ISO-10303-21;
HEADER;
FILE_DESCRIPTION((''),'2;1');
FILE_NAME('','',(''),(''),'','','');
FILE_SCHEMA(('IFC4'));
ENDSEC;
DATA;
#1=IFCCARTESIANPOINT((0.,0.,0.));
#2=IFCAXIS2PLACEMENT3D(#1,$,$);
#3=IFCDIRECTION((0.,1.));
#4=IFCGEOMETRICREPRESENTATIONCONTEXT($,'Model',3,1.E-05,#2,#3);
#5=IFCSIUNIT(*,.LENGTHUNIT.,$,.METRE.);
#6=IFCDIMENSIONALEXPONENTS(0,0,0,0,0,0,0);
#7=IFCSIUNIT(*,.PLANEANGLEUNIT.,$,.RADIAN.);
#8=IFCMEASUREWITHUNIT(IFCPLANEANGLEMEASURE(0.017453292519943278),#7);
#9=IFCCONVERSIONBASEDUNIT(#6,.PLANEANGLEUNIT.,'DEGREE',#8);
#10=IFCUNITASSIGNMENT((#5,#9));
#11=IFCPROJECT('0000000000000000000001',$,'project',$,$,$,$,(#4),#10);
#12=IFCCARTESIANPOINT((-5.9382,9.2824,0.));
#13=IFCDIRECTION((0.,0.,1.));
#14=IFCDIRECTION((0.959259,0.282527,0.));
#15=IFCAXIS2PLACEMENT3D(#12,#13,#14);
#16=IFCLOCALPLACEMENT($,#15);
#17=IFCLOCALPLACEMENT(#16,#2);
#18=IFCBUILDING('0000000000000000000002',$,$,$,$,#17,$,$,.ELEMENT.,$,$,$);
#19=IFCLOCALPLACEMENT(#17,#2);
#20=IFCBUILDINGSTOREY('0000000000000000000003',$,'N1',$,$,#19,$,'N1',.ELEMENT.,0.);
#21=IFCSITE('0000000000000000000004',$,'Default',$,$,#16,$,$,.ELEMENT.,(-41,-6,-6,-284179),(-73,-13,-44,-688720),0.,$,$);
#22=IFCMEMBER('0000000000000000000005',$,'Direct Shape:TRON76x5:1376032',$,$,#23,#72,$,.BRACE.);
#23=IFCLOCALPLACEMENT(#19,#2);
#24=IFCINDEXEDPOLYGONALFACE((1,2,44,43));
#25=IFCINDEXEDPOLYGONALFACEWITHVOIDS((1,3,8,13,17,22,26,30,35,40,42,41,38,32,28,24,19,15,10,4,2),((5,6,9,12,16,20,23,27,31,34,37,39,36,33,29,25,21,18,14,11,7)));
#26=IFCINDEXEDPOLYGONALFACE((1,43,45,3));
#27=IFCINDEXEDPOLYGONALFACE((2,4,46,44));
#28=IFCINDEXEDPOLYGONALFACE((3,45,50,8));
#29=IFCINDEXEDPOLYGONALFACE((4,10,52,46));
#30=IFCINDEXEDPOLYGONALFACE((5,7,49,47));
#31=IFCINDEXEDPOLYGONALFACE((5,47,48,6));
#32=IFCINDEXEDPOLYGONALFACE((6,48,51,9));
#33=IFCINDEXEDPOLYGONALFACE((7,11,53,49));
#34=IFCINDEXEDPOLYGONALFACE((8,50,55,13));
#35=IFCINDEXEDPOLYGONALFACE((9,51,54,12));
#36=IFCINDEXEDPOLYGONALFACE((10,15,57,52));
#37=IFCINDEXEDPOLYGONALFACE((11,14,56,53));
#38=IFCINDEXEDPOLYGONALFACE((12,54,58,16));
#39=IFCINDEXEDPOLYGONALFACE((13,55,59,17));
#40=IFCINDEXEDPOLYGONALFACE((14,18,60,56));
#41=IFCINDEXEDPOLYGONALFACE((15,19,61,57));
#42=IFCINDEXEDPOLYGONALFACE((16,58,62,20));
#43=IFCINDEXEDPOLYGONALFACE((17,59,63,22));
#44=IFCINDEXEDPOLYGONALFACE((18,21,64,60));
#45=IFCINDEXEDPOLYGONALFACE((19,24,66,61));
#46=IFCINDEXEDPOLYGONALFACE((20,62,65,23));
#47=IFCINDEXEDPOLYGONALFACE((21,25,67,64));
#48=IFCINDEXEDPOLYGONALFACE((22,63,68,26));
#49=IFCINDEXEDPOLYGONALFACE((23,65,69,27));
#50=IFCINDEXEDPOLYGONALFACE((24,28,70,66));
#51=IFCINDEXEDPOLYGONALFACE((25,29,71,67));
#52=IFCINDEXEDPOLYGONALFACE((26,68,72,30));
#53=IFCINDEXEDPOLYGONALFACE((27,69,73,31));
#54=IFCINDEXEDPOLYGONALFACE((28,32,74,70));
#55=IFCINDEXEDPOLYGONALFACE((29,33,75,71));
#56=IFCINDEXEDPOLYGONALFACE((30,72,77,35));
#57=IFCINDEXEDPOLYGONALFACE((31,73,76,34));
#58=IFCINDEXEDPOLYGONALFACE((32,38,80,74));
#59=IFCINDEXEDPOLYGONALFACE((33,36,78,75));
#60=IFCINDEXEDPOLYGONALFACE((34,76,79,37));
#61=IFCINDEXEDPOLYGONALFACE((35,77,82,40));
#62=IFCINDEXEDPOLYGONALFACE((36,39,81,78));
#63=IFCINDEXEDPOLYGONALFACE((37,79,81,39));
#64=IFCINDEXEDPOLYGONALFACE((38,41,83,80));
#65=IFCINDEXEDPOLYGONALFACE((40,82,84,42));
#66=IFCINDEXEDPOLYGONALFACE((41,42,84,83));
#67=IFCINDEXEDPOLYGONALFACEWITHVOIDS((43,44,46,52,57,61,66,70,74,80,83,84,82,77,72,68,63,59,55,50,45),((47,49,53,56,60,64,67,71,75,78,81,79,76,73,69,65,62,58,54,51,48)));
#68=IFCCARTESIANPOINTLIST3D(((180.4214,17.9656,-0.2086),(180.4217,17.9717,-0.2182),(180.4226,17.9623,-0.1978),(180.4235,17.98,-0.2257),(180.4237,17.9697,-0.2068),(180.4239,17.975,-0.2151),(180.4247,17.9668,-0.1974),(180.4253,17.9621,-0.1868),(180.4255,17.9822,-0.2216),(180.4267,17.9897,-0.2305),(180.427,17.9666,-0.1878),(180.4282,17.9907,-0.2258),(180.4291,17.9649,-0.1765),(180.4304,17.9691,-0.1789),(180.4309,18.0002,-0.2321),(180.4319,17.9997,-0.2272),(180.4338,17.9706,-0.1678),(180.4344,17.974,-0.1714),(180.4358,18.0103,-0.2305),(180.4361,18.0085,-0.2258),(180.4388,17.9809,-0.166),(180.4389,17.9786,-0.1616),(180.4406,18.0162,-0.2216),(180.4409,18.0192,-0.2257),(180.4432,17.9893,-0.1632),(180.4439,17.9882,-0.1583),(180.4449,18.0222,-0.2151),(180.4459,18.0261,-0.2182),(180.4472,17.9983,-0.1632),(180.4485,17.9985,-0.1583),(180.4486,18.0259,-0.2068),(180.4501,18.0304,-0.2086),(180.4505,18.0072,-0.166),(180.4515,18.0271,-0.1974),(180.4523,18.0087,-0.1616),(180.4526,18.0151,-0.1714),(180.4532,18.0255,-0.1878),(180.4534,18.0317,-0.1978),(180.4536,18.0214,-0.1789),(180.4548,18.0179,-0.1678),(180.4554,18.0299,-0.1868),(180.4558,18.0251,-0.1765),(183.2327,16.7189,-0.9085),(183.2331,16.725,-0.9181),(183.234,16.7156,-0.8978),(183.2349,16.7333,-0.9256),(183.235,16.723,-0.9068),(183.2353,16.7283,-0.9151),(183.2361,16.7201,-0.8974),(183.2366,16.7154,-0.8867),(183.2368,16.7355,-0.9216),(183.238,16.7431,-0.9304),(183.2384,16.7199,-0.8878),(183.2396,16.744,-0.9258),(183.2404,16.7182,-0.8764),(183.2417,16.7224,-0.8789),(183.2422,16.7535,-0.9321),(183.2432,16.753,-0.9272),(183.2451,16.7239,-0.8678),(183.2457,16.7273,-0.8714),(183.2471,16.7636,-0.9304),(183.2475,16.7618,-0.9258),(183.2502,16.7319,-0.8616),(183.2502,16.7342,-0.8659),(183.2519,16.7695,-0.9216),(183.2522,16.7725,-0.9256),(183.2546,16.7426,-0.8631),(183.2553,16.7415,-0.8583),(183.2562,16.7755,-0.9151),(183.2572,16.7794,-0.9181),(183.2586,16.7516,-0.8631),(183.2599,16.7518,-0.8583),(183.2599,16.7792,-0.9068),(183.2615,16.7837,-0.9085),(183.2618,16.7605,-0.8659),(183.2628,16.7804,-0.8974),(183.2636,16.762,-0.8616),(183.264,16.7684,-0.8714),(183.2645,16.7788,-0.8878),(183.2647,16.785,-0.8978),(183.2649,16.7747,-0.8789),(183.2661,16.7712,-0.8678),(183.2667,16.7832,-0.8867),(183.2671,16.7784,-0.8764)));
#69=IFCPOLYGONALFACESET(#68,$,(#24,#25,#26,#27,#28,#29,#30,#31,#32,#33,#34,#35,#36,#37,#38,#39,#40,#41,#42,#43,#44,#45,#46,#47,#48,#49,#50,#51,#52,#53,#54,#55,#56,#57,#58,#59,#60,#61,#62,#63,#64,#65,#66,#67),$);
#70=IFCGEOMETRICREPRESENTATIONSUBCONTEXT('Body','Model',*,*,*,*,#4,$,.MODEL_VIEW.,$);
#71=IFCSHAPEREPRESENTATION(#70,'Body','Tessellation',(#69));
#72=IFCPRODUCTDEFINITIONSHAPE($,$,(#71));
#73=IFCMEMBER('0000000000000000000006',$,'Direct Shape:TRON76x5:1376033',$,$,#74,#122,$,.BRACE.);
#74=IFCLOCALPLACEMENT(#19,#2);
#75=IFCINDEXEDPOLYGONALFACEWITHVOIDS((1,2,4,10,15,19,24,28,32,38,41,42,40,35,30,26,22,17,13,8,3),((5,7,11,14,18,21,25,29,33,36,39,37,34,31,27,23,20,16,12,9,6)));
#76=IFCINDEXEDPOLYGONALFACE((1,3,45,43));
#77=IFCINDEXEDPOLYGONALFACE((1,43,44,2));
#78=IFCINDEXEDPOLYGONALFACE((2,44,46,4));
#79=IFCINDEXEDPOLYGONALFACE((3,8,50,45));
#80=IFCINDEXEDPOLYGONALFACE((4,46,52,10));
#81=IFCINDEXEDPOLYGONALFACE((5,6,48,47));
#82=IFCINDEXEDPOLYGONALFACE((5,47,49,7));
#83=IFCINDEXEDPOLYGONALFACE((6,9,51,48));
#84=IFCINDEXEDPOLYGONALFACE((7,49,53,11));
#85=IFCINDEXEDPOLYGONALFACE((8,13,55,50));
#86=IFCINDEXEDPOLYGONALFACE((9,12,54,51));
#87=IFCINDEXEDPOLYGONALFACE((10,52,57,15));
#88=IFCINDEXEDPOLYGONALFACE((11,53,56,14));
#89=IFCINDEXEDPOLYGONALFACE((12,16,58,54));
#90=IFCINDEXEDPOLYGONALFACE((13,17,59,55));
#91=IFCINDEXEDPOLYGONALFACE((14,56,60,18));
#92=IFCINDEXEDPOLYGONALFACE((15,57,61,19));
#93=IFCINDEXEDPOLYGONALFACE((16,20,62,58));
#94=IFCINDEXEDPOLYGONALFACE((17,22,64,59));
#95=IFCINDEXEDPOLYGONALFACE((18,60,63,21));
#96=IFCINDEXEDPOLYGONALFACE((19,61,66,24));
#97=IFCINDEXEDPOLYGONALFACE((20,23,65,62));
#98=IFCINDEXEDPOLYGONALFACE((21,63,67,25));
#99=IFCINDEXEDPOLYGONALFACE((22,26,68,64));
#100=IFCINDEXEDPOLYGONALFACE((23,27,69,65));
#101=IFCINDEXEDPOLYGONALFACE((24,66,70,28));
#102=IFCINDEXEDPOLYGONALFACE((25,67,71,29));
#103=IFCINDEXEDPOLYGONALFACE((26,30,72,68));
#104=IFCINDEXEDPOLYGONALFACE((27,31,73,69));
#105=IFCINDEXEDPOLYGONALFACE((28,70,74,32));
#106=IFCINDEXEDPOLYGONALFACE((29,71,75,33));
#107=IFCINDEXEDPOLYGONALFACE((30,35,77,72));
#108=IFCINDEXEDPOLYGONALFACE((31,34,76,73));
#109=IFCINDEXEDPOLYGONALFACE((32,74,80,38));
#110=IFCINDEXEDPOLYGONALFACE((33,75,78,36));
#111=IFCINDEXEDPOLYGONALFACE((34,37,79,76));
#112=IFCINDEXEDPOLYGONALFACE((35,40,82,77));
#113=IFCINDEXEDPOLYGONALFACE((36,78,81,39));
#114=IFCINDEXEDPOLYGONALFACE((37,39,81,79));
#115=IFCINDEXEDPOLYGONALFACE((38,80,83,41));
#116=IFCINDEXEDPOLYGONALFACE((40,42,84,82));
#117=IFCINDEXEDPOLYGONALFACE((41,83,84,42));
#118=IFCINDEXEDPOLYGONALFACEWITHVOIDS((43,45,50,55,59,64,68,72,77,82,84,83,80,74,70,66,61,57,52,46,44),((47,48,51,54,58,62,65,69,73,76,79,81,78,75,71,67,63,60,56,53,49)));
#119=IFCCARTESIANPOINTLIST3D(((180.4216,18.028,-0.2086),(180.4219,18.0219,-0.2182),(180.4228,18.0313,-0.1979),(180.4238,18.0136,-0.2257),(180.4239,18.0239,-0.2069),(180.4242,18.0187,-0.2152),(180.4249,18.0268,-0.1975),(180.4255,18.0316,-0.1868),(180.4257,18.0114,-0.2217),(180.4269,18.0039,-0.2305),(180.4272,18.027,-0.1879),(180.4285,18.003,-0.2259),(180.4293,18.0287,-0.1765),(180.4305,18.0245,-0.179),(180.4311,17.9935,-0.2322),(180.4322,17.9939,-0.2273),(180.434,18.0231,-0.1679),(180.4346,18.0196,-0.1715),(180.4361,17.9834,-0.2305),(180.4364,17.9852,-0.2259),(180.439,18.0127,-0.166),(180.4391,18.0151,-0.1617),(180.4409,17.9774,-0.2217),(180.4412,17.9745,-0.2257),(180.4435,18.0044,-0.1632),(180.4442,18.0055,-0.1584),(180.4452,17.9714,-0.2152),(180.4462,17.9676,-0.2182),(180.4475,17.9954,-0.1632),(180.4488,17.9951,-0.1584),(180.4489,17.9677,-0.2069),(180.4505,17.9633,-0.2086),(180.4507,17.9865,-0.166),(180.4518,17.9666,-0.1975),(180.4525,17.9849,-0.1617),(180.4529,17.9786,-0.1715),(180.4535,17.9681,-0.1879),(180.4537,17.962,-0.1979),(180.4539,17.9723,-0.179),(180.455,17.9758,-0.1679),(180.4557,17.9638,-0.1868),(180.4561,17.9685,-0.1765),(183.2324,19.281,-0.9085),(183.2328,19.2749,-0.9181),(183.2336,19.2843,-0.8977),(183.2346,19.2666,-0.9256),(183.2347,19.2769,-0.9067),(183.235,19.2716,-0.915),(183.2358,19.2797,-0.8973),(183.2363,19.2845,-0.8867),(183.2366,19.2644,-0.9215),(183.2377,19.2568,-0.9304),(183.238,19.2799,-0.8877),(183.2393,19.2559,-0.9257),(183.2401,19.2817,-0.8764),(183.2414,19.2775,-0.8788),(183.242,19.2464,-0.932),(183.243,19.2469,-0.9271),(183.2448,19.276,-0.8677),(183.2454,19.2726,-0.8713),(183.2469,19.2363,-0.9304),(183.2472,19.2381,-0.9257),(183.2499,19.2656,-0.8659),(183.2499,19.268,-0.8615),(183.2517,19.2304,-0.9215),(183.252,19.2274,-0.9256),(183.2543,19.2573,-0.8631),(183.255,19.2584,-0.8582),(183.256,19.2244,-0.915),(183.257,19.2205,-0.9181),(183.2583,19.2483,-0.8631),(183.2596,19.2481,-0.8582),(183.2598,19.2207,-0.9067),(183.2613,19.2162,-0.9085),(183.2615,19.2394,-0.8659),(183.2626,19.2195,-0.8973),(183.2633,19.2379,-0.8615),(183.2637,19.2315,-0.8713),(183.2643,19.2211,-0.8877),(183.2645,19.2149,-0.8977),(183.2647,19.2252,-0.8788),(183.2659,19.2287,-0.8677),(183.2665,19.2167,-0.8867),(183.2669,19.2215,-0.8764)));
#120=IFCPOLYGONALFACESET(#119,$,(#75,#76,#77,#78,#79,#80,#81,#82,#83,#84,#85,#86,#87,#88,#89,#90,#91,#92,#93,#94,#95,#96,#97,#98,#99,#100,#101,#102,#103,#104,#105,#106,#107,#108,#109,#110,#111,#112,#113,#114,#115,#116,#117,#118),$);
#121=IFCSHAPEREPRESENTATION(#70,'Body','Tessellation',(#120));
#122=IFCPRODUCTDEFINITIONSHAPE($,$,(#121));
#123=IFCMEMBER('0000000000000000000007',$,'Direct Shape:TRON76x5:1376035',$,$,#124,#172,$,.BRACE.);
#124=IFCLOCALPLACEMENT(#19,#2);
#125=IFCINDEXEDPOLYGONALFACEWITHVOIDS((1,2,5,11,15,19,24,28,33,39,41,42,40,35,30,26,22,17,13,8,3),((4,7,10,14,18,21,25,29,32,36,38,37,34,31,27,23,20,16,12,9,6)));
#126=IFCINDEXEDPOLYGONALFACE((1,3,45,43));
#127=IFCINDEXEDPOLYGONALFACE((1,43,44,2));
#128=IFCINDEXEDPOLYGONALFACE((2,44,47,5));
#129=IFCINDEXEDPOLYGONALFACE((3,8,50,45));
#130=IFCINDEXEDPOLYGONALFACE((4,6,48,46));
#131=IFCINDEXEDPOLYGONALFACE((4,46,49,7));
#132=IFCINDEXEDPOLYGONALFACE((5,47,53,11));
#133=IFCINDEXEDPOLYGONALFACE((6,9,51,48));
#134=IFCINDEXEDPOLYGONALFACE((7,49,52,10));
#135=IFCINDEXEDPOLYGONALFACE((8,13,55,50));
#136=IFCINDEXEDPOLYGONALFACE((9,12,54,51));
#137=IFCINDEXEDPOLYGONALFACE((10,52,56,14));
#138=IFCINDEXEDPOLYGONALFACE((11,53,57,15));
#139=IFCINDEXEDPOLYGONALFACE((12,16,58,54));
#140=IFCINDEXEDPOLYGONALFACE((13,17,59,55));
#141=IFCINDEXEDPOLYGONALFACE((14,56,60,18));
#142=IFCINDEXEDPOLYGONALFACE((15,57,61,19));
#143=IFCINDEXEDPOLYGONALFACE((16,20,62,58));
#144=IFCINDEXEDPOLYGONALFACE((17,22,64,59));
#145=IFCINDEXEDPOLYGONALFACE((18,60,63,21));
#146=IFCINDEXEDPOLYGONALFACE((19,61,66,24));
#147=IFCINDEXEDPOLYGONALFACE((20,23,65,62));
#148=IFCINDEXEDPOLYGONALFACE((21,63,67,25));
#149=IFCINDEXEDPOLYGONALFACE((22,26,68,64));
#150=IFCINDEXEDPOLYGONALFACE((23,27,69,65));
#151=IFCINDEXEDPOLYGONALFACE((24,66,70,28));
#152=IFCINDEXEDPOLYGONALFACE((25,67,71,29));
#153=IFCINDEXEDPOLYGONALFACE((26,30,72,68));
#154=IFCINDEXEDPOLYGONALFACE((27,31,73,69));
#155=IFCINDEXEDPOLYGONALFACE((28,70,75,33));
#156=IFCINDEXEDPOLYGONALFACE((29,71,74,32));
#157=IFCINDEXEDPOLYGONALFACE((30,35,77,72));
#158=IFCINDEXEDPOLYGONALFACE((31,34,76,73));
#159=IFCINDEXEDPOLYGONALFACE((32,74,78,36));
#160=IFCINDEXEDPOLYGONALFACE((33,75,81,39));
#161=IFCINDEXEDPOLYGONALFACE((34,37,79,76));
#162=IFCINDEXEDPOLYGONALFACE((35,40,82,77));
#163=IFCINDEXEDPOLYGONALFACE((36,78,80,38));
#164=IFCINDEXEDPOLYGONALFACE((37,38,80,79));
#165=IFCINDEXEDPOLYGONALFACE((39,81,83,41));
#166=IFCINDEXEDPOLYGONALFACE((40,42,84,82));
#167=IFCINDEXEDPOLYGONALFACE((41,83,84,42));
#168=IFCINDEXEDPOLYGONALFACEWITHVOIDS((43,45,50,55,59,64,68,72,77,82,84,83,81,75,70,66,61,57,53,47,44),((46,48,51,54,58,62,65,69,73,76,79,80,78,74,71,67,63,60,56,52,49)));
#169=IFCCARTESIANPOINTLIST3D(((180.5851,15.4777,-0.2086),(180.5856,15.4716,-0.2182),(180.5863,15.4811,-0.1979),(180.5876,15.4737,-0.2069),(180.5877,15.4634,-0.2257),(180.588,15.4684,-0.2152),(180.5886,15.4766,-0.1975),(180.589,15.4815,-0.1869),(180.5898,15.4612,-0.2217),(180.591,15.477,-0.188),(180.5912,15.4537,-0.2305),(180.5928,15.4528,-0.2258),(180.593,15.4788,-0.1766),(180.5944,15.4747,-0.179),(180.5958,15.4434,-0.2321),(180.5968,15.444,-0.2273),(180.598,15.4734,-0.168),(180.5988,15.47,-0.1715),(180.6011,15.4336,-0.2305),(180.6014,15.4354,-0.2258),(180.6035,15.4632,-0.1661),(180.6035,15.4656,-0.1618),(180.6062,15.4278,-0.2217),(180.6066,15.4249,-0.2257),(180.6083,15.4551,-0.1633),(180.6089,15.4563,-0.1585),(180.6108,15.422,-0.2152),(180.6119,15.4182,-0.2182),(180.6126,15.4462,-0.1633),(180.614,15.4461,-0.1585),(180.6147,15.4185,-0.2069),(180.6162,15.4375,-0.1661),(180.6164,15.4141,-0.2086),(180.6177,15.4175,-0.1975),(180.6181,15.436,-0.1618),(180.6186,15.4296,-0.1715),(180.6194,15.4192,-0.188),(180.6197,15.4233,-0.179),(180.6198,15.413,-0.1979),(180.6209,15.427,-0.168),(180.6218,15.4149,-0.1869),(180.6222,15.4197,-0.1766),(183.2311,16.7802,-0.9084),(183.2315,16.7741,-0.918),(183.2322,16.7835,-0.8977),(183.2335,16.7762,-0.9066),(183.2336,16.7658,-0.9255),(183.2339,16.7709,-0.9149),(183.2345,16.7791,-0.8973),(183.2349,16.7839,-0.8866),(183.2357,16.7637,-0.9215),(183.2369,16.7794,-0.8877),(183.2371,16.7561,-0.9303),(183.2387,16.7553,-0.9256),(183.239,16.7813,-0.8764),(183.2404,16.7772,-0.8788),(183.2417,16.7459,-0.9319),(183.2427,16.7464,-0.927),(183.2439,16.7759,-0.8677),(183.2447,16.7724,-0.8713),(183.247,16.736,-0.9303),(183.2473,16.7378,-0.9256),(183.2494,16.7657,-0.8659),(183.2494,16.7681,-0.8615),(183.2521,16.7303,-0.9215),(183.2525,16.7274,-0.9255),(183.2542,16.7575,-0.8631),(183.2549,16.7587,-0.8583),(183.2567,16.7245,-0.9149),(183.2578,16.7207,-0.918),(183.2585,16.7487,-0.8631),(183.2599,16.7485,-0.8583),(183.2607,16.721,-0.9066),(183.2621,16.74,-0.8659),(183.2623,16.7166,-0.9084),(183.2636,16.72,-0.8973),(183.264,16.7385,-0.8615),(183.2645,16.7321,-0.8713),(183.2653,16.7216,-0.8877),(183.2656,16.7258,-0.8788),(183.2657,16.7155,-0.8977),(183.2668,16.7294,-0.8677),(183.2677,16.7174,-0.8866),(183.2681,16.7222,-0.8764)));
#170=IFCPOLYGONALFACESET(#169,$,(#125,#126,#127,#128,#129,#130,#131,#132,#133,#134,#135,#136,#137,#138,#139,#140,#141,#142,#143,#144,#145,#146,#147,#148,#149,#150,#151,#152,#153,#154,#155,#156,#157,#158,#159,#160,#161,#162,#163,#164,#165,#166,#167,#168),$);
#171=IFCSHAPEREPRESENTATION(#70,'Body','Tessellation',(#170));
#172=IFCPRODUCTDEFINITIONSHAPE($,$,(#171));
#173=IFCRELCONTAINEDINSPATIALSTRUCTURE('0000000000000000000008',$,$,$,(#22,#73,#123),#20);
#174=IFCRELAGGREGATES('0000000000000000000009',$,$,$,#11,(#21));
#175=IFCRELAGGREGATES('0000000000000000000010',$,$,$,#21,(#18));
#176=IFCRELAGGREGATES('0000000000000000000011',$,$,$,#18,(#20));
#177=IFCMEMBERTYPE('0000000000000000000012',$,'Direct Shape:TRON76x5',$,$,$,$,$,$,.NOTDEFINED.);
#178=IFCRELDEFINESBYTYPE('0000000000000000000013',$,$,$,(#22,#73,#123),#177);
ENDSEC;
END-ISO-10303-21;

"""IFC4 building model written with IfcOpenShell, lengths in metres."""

from ifc_helpers import new_model, entity, si_unit, converted_unit, direction, frame, frame_2d, origin, place, context, subcontext, project, spatial, hollow_circle, extrude, type_object, element, save


model = new_model("IFC4")

# Units and contexts
model_context = context("Model", 3, precision=1e-05, world=origin(), true_north=direction((0.0, 1.0)))
body_context = subcontext(model_context, "Body", "Model", "MODEL_VIEW")
ifc_project = project(units=[si_unit("LENGTHUNIT", "METRE"), converted_unit("PLANEANGLEUNIT", "DEGREE", entity("IfcPlaneAngleMeasure", 0.017453292519943278), si_unit("PLANEANGLEUNIT", "RADIAN"), dimensions=[0, 0, 0, 0, 0, 0, 0])], contexts=[model_context])

# Site, building, storey
site_placement = place(None, frame((-5.9382, 9.2824, 0.0), z_axis=(0.0, 0.0, 1.0), x_axis=(0.959259, 0.282527, 0.0)))
site = spatial("IfcSite", under=ifc_project, at=site_placement, Name="Default", CompositionType="ELEMENT", RefLatitude=(-41, -6, -6, -284179), RefLongitude=(-73, -13, -44, -688720), RefElevation=0.0)
building_placement = place(site_placement, origin())
building = spatial("IfcBuilding", under=site, at=building_placement, CompositionType="ELEMENT")
storey_placement = place(building_placement, origin())
storey = spatial("IfcBuildingStorey", under=building, at=storey_placement, Name="N1", LongName="N1", CompositionType="ELEMENT", Elevation=0.0)

# Members
member_type_1 = type_object("IfcMemberType", Name="Direct Shape:TRON76x5", PredefinedType="NOTDEFINED")
member_1_placement = place(storey_placement, origin())
element("IfcMember", 1, at=member_1_placement, inside=storey, type_object=member_type_1, Name="Direct Shape:TRON76x5:1376032", PredefinedType="BRACE", context=body_context, shape_type="SweptSolid", body=[
    extrude(hollow_circle(Radius=0.0381, WallThickness=0.005, at=frame_2d((0.0, 0.0), x_axis=(1.0, 0.0))), frame((180.4386, 17.9967, -0.195), z_axis=(0.89135, -0.395275, -0.221928), x_axis=(-0.202875, 0.089966, -0.975063)), (0.0, 0.0, 1.0), 3.154),
])
member_2_placement = place(storey_placement, origin())
element("IfcMember", 2, at=member_2_placement, inside=storey, type_object=member_type_1, Name="Direct Shape:TRON76x5:1376033", PredefinedType="BRACE", context=body_context, shape_type="SweptSolid", body=[
    extrude(hollow_circle(Radius=0.0381, WallThickness=0.005, at=frame_2d((0.0, 0.0), x_axis=(1.0, 0.0))), frame((180.4389, 17.9969, -0.1951), z_axis=(0.890627, 0.397004, -0.221748), x_axis=(-0.202537, -0.090283, -0.975104)), (0.0, 0.0, 1.0), 3.156),
])
member_3_placement = place(storey_placement, origin())
element("IfcMember", 3, at=member_3_placement, inside=storey, type_object=member_type_1, Name="Direct Shape:TRON76x5:1376035", PredefinedType="BRACE", context=body_context, shape_type="SweptSolid", body=[
    extrude(hollow_circle(Radius=0.0381, WallThickness=0.005, at=frame_2d((0.0, 0.0), x_axis=(1.0, 0.0))), frame((180.6037, 15.4473, -0.1951), z_axis=(0.872951, 0.429714, -0.230873), x_axis=(-0.207137, -0.101964, -0.972984)), (0.0, 0.0, 1.0), 3.031),
])

save(model, "model.ifc")
